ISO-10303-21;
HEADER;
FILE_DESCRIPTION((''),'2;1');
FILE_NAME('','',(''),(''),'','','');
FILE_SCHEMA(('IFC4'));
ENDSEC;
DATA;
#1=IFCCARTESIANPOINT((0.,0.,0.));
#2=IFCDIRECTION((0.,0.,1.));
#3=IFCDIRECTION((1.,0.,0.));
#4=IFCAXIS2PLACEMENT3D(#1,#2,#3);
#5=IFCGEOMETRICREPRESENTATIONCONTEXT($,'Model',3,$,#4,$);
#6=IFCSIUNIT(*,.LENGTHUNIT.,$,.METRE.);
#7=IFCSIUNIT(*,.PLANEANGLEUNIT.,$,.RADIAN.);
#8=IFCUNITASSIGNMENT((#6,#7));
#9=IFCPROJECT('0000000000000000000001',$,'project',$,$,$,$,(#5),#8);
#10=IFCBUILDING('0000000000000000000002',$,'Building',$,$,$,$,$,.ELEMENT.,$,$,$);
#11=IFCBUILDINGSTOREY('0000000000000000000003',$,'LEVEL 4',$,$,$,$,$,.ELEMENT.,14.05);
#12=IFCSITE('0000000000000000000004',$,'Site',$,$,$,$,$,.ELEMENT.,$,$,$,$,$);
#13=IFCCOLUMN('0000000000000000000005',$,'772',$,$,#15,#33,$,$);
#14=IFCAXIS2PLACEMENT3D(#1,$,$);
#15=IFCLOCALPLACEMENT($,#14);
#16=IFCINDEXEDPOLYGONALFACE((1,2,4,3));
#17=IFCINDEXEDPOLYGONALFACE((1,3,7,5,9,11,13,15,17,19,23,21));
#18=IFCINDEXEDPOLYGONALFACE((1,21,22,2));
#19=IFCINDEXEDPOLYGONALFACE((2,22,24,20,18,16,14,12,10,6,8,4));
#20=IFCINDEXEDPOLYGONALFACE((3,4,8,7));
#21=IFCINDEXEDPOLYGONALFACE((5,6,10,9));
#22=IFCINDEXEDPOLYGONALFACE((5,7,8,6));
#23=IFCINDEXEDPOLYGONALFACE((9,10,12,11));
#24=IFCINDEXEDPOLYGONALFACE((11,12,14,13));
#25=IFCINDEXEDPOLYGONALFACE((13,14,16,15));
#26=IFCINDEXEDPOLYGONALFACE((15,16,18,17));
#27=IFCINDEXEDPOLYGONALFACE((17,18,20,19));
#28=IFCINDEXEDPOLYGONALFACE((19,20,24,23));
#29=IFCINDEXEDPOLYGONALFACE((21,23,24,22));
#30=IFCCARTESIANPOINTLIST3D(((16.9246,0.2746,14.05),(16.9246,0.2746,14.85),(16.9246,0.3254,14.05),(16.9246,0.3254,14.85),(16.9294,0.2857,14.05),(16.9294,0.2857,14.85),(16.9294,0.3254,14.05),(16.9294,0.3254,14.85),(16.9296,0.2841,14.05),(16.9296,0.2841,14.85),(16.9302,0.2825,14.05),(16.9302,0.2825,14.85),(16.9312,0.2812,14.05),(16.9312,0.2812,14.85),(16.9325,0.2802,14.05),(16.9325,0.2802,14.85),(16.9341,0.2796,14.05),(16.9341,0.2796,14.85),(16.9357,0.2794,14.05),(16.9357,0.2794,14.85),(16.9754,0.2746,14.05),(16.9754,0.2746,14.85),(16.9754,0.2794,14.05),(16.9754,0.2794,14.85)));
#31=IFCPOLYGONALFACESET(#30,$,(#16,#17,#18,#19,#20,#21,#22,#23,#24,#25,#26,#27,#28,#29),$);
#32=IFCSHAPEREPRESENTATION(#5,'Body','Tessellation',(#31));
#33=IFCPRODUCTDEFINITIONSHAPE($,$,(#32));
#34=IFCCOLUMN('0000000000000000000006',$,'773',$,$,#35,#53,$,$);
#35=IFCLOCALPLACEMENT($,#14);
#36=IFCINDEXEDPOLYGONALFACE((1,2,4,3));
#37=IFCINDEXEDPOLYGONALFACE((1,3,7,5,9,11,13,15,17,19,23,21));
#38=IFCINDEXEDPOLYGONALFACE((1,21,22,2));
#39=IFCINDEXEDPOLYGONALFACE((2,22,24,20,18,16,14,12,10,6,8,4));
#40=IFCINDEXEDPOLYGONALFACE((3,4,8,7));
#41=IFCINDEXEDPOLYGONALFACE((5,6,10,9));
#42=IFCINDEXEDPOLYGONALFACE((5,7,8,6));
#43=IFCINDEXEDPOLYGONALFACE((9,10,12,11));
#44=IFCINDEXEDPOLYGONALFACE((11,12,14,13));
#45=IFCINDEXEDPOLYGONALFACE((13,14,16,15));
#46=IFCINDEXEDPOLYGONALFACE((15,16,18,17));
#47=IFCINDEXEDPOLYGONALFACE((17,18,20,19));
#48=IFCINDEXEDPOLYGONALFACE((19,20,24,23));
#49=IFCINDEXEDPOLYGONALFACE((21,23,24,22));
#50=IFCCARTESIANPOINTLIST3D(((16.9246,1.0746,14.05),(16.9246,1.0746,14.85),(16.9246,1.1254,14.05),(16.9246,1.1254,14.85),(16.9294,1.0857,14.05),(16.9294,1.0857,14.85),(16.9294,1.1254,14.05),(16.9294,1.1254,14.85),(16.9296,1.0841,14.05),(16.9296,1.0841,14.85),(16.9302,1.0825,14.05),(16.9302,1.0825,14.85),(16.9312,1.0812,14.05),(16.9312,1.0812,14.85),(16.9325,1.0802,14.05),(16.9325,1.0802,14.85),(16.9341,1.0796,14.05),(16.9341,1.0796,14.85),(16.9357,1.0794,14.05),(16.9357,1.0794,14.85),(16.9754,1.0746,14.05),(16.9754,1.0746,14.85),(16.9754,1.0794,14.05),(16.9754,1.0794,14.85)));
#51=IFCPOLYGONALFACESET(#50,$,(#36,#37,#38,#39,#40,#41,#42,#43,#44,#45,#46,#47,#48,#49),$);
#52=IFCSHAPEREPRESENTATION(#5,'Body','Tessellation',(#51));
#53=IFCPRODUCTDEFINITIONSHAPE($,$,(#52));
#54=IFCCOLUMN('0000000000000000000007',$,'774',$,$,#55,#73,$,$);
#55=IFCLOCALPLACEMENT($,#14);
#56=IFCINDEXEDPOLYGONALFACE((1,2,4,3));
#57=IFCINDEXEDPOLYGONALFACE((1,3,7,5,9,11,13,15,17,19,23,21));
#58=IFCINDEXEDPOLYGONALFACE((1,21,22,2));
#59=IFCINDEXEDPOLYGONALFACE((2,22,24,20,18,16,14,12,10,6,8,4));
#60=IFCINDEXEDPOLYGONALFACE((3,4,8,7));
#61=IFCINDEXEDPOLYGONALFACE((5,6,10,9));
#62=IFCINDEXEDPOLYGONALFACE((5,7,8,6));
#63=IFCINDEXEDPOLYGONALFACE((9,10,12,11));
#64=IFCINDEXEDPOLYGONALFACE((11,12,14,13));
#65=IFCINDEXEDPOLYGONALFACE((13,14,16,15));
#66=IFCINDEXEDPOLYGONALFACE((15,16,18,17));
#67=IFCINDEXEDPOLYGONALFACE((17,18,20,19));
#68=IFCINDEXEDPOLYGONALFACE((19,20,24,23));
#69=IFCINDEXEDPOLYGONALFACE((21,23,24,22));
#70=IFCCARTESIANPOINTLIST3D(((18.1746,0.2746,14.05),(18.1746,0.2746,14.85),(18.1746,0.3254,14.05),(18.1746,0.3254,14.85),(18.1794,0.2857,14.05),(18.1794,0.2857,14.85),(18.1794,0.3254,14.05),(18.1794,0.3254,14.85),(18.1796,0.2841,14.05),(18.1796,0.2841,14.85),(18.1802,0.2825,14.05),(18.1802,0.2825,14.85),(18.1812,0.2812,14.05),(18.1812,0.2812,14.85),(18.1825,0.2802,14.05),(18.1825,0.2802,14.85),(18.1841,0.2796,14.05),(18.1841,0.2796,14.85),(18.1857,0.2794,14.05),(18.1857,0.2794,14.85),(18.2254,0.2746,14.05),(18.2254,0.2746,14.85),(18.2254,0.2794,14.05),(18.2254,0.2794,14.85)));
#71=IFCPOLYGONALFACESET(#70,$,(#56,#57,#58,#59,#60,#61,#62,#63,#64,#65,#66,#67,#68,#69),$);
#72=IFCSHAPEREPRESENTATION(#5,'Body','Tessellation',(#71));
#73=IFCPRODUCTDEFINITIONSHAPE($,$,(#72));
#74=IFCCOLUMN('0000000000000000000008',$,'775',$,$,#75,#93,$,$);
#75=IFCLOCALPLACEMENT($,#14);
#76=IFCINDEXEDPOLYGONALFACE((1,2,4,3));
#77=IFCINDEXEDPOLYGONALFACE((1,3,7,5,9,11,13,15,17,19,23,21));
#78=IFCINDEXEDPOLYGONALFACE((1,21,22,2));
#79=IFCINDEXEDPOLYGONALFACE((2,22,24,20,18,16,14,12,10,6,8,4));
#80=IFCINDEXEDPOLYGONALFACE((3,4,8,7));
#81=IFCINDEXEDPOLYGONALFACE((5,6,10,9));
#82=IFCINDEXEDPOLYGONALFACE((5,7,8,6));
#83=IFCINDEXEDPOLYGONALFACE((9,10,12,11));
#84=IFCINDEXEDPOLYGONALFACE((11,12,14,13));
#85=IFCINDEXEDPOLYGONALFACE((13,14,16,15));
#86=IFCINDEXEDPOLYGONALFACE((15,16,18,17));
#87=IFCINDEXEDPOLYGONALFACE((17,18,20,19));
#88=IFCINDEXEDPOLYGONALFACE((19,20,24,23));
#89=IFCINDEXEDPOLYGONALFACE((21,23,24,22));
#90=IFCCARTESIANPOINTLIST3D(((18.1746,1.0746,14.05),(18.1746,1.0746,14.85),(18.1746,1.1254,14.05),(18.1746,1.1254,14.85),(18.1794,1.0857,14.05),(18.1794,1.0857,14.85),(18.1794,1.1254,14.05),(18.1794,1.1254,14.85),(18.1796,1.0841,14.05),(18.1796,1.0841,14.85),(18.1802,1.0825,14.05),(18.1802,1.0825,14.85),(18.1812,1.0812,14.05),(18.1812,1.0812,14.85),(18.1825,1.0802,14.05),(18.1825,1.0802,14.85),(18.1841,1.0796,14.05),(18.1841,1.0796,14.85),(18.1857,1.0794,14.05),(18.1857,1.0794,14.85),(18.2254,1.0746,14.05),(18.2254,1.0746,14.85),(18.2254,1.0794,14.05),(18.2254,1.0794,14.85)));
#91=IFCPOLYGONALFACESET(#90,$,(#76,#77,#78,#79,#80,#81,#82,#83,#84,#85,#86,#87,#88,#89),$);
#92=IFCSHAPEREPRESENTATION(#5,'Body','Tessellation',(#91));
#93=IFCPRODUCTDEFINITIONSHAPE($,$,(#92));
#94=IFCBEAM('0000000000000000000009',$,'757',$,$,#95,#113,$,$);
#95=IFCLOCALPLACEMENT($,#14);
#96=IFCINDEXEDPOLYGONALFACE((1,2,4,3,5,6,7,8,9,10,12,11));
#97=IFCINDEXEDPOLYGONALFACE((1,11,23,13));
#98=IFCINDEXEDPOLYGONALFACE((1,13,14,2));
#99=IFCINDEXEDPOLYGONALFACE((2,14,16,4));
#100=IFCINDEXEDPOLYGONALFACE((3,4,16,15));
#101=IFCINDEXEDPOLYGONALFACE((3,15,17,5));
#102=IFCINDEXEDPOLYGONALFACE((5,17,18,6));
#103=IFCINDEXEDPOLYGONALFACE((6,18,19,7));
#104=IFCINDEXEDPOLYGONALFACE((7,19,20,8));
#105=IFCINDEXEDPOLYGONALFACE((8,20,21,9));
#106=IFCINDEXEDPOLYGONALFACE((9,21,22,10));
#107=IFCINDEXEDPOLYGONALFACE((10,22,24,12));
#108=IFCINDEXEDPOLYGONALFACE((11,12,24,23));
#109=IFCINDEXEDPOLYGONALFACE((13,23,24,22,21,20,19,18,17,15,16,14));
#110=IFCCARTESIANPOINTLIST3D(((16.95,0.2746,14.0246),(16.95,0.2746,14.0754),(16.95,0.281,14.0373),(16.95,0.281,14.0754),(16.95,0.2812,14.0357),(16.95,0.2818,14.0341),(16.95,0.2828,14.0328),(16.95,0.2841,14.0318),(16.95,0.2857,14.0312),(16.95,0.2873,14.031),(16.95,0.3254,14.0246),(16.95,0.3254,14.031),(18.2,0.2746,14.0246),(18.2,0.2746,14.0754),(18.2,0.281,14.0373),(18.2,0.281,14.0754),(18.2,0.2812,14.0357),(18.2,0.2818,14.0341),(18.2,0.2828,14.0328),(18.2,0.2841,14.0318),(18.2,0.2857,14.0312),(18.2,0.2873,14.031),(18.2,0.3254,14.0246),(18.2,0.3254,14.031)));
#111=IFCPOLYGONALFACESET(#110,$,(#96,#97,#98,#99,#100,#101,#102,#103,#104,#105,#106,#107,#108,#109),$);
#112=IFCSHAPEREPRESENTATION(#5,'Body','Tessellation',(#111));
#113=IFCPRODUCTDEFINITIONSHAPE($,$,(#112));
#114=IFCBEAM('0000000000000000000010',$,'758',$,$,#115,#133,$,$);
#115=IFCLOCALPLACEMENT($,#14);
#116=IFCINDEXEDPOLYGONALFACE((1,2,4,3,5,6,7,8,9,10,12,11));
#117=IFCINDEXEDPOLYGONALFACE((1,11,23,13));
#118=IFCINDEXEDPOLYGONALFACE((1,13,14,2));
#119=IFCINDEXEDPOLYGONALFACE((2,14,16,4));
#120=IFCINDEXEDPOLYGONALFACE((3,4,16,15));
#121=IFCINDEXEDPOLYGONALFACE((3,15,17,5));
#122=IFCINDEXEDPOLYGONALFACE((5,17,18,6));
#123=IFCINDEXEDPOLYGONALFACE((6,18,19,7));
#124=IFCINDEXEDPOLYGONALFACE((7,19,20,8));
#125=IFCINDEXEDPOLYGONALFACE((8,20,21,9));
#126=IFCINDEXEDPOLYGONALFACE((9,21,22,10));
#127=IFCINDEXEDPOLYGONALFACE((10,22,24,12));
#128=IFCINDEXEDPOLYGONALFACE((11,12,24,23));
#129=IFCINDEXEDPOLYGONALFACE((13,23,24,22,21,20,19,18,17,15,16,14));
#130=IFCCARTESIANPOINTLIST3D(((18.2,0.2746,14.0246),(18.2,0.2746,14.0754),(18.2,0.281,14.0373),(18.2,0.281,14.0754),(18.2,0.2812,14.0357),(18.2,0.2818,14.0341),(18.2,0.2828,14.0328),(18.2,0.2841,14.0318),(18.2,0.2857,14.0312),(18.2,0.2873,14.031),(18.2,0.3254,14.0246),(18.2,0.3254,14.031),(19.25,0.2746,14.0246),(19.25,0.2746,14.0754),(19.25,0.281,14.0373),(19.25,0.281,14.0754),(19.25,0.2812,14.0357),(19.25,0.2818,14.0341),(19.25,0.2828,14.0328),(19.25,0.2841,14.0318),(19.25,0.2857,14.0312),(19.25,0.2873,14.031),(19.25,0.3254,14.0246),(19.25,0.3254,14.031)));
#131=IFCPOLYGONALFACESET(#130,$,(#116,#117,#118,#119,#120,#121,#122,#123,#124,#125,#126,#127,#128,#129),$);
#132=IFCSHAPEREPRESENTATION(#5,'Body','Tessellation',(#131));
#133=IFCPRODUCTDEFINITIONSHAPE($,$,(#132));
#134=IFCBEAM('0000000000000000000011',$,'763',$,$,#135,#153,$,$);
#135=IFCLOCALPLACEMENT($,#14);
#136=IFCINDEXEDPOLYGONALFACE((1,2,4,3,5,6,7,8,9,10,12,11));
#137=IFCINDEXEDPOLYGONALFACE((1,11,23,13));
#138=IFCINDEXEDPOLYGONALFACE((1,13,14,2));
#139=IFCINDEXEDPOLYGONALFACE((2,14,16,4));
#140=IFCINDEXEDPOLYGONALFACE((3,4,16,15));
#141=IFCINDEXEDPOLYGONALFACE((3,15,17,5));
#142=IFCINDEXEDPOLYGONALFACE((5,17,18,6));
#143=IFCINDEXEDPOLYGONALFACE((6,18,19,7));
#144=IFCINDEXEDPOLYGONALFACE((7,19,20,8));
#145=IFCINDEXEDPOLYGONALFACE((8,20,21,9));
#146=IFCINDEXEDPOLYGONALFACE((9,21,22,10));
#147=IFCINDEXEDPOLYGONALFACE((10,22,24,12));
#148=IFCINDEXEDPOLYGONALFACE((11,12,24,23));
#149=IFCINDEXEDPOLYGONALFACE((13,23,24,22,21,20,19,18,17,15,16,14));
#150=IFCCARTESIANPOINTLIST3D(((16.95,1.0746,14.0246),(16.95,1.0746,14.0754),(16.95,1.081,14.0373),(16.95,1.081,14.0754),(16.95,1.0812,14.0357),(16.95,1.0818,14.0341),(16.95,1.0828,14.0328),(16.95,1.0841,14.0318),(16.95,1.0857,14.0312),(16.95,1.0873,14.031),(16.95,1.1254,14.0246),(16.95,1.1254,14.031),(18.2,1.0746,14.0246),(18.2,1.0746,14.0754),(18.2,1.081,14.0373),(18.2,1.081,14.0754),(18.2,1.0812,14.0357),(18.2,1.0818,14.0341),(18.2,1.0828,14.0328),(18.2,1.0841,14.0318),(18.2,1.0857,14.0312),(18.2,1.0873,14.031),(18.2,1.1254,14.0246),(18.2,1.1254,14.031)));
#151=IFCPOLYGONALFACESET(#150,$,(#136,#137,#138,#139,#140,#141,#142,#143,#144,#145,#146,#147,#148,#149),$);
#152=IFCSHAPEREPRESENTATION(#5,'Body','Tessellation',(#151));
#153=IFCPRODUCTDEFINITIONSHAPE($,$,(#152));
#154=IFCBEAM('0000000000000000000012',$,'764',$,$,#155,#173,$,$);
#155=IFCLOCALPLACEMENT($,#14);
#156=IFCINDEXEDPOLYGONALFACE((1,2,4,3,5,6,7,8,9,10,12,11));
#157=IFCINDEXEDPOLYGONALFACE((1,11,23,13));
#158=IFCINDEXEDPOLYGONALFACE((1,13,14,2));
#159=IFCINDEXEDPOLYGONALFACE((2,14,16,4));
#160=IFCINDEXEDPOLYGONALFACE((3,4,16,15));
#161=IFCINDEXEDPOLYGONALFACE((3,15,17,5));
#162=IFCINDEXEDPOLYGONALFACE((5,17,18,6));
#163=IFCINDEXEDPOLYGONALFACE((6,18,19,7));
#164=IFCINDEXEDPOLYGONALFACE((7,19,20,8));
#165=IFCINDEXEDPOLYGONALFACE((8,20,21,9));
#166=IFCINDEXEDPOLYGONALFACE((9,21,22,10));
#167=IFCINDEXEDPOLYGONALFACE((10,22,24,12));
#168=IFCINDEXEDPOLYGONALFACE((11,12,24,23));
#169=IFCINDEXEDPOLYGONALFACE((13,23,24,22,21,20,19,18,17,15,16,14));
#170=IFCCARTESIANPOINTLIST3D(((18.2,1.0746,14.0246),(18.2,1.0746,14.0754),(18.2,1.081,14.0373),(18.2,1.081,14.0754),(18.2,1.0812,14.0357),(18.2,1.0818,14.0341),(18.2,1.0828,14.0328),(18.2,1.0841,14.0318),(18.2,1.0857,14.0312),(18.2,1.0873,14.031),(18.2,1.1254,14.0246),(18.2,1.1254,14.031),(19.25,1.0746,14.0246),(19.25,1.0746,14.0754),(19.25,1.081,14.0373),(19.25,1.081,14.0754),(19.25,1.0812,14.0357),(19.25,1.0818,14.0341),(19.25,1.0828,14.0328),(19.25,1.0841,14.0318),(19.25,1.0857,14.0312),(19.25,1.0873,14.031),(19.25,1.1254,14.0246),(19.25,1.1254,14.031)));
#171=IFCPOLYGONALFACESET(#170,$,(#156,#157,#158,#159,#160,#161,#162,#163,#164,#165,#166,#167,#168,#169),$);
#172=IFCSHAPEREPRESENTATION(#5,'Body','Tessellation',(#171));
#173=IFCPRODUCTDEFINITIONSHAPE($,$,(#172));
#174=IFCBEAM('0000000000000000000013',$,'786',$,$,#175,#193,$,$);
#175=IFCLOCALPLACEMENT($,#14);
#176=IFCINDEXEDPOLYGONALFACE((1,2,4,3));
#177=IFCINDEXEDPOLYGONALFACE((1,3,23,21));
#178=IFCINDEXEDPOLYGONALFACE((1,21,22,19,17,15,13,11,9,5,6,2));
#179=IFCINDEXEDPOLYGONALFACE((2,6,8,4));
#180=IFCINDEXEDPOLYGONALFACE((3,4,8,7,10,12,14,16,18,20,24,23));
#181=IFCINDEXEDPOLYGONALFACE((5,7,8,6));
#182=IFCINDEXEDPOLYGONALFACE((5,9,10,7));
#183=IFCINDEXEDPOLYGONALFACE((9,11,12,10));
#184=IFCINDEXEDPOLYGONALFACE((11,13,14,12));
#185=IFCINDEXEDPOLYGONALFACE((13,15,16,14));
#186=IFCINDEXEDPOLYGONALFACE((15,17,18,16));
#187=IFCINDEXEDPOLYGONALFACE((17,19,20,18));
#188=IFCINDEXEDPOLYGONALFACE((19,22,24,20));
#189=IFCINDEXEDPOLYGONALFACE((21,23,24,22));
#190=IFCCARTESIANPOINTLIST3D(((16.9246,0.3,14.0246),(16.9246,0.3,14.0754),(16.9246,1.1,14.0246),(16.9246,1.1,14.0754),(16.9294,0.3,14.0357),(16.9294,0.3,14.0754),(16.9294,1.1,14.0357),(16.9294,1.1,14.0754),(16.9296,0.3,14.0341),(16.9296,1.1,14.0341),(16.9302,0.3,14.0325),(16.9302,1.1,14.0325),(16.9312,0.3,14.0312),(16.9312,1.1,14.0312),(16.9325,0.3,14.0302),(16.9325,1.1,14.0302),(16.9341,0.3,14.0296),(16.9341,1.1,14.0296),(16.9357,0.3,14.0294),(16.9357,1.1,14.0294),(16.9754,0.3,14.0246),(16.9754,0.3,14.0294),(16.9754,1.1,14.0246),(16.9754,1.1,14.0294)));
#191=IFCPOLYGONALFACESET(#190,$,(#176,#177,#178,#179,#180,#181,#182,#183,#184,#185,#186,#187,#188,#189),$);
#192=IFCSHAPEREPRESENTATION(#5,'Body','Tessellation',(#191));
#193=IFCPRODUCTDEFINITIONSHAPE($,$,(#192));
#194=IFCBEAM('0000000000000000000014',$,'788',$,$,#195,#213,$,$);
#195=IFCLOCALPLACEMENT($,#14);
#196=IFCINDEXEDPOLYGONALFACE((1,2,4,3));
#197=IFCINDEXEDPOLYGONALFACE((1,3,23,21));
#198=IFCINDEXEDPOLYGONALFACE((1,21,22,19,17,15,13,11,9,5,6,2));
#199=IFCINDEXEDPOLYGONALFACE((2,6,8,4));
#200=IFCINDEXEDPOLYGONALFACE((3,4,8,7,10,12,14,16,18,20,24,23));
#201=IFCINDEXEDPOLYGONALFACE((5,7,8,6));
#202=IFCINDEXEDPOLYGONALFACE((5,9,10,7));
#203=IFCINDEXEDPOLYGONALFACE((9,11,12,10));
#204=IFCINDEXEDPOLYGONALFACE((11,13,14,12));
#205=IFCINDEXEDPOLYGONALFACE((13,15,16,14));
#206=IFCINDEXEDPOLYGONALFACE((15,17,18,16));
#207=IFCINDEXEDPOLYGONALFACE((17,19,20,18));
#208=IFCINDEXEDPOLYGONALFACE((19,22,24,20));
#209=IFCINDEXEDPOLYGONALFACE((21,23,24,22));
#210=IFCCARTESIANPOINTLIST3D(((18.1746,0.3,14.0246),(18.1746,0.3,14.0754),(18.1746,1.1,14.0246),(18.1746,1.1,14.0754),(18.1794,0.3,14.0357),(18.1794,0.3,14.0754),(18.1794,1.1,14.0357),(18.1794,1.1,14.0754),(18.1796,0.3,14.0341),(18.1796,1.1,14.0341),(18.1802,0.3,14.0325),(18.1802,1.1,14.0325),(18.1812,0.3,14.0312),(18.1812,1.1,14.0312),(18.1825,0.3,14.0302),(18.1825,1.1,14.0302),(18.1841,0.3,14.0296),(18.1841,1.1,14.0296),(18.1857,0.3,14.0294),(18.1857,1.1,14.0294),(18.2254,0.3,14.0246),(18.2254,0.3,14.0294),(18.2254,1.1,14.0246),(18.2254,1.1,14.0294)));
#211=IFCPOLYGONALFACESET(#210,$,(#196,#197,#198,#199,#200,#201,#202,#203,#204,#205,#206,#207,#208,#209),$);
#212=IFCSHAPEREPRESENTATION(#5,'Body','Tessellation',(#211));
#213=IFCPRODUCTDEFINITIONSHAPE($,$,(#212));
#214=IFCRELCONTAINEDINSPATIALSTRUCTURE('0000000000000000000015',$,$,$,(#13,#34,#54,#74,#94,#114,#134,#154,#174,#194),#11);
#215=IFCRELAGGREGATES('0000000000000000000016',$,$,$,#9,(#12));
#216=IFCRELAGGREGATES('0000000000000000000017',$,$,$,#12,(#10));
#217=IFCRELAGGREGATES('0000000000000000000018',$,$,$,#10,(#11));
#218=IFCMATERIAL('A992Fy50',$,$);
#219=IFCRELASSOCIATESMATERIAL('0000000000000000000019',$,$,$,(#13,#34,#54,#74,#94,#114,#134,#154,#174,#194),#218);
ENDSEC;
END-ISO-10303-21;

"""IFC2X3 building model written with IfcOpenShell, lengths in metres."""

from ifc_helpers import new_model, si_unit, frame, origin_with_axes, origin_2d_with_axis, place, context, project, spatial, l_section, extrude, material, element, save


model = new_model("IFC2X3")

# Units and contexts
model_context = context("Model", 3, world=origin_with_axes())
ifc_project = project(units=[si_unit("LENGTHUNIT", "METRE"), si_unit("PLANEANGLEUNIT", "RADIAN")], contexts=[model_context])

# Site, building, storey
site = spatial("IfcSite", under=ifc_project, Name="Site", CompositionType="ELEMENT")
building = spatial("IfcBuilding", under=site, Name="Building", CompositionType="ELEMENT")
storey = spatial("IfcBuildingStorey", under=building, Name="LEVEL 4", CompositionType="ELEMENT", Elevation=14.05)

# Columns
ifc_material = material(Name="A992Fy50")
for number, where, z_axis, x_axis, name in (
    (1, (16.95, 0.3, 14.85), (0.0, 0.0, -1.0), (0.0, 1.0, 0.0), "772"),
    (2, (16.95, 1.1, 14.85), (0.0, 0.0, -1.0), (0.0, 1.0, 0.0), "773"),
    (3, (18.2, 0.3, 14.85), (0.0, 0.0, -1.0), (0.0, 1.0, 0.0), "774"),
    (4, (18.2, 1.1, 14.85), (0.0, 0.0, -1.0), (0.0, 1.0, 0.0), "775"),
):
    element("IfcColumn", number, at=place(None, frame(where, z_axis=z_axis, x_axis=x_axis)), inside=storey, material=ifc_material, Name=name, context=model_context, shape_type="SweptSolid", body=[
        extrude(l_section(Depth=0.0508, Width=0.0508, Thickness=0.0048, FilletRadius=0.0063, at=origin_2d_with_axis()), origin_with_axes(), (0.0, 0.0, 1.0), 0.8),
    ])

# Beams
beam_1_placement = place(None, frame((16.95, 0.3, 14.05), z_axis=(1.0, 0.0, 0.0), x_axis=(0.0, 1.0, 0.0)))
element("IfcBeam", 5, at=beam_1_placement, inside=storey, material=ifc_material, Name="757", context=model_context, shape_type="SweptSolid", body=[
    extrude(l_section(Depth=0.0508, Width=0.0508, Thickness=0.0063, FilletRadius=0.0063, at=origin_2d_with_axis()), origin_with_axes(), (0.0, 0.0, 1.0), 1.25),
])
beam_2_placement = place(None, frame((18.2, 0.3, 14.05), z_axis=(1.0, 0.0, 0.0), x_axis=(0.0, 1.0, 0.0)))
element("IfcBeam", 6, at=beam_2_placement, inside=storey, material=ifc_material, Name="758", context=model_context, shape_type="SweptSolid", body=[
    extrude(l_section(Depth=0.0508, Width=0.0508, Thickness=0.0063, FilletRadius=0.0063, at=origin_2d_with_axis()), origin_with_axes(), (0.0, 0.0, 1.0), 1.05),
])
beam_3_placement = place(None, frame((16.95, 1.1, 14.05), z_axis=(1.0, 0.0, 0.0), x_axis=(0.0, 1.0, 0.0)))
element("IfcBeam", 7, at=beam_3_placement, inside=storey, material=ifc_material, Name="763", context=model_context, shape_type="SweptSolid", body=[
    extrude(l_section(Depth=0.0508, Width=0.0508, Thickness=0.0063, FilletRadius=0.0063, at=origin_2d_with_axis()), origin_with_axes(), (0.0, 0.0, 1.0), 1.25),
])
beam_4_placement = place(None, frame((18.2, 1.1, 14.05), z_axis=(1.0, 0.0, 0.0), x_axis=(0.0, 1.0, 0.0)))
element("IfcBeam", 8, at=beam_4_placement, inside=storey, material=ifc_material, Name="764", context=model_context, shape_type="SweptSolid", body=[
    extrude(l_section(Depth=0.0508, Width=0.0508, Thickness=0.0063, FilletRadius=0.0063, at=origin_2d_with_axis()), origin_with_axes(), (0.0, 0.0, 1.0), 1.05),
])
for number, where, z_axis, x_axis, name in (
    (9, (16.95, 1.1, 14.05), (0.0, -1.0, 0.0), (1.0, 0.0, 0.0), "786"),
    (10, (18.2, 1.1, 14.05), (0.0, -1.0, 0.0), (1.0, 0.0, 0.0), "788"),
):
    element("IfcBeam", number, at=place(None, frame(where, z_axis=z_axis, x_axis=x_axis)), inside=storey, material=ifc_material, Name=name, context=model_context, shape_type="SweptSolid", body=[
        extrude(l_section(Depth=0.0508, Width=0.0508, Thickness=0.0048, FilletRadius=0.0063, at=origin_2d_with_axis()), origin_with_axes(), (0.0, 0.0, 1.0), 0.8),
    ])

save(model, "model.ifc")
